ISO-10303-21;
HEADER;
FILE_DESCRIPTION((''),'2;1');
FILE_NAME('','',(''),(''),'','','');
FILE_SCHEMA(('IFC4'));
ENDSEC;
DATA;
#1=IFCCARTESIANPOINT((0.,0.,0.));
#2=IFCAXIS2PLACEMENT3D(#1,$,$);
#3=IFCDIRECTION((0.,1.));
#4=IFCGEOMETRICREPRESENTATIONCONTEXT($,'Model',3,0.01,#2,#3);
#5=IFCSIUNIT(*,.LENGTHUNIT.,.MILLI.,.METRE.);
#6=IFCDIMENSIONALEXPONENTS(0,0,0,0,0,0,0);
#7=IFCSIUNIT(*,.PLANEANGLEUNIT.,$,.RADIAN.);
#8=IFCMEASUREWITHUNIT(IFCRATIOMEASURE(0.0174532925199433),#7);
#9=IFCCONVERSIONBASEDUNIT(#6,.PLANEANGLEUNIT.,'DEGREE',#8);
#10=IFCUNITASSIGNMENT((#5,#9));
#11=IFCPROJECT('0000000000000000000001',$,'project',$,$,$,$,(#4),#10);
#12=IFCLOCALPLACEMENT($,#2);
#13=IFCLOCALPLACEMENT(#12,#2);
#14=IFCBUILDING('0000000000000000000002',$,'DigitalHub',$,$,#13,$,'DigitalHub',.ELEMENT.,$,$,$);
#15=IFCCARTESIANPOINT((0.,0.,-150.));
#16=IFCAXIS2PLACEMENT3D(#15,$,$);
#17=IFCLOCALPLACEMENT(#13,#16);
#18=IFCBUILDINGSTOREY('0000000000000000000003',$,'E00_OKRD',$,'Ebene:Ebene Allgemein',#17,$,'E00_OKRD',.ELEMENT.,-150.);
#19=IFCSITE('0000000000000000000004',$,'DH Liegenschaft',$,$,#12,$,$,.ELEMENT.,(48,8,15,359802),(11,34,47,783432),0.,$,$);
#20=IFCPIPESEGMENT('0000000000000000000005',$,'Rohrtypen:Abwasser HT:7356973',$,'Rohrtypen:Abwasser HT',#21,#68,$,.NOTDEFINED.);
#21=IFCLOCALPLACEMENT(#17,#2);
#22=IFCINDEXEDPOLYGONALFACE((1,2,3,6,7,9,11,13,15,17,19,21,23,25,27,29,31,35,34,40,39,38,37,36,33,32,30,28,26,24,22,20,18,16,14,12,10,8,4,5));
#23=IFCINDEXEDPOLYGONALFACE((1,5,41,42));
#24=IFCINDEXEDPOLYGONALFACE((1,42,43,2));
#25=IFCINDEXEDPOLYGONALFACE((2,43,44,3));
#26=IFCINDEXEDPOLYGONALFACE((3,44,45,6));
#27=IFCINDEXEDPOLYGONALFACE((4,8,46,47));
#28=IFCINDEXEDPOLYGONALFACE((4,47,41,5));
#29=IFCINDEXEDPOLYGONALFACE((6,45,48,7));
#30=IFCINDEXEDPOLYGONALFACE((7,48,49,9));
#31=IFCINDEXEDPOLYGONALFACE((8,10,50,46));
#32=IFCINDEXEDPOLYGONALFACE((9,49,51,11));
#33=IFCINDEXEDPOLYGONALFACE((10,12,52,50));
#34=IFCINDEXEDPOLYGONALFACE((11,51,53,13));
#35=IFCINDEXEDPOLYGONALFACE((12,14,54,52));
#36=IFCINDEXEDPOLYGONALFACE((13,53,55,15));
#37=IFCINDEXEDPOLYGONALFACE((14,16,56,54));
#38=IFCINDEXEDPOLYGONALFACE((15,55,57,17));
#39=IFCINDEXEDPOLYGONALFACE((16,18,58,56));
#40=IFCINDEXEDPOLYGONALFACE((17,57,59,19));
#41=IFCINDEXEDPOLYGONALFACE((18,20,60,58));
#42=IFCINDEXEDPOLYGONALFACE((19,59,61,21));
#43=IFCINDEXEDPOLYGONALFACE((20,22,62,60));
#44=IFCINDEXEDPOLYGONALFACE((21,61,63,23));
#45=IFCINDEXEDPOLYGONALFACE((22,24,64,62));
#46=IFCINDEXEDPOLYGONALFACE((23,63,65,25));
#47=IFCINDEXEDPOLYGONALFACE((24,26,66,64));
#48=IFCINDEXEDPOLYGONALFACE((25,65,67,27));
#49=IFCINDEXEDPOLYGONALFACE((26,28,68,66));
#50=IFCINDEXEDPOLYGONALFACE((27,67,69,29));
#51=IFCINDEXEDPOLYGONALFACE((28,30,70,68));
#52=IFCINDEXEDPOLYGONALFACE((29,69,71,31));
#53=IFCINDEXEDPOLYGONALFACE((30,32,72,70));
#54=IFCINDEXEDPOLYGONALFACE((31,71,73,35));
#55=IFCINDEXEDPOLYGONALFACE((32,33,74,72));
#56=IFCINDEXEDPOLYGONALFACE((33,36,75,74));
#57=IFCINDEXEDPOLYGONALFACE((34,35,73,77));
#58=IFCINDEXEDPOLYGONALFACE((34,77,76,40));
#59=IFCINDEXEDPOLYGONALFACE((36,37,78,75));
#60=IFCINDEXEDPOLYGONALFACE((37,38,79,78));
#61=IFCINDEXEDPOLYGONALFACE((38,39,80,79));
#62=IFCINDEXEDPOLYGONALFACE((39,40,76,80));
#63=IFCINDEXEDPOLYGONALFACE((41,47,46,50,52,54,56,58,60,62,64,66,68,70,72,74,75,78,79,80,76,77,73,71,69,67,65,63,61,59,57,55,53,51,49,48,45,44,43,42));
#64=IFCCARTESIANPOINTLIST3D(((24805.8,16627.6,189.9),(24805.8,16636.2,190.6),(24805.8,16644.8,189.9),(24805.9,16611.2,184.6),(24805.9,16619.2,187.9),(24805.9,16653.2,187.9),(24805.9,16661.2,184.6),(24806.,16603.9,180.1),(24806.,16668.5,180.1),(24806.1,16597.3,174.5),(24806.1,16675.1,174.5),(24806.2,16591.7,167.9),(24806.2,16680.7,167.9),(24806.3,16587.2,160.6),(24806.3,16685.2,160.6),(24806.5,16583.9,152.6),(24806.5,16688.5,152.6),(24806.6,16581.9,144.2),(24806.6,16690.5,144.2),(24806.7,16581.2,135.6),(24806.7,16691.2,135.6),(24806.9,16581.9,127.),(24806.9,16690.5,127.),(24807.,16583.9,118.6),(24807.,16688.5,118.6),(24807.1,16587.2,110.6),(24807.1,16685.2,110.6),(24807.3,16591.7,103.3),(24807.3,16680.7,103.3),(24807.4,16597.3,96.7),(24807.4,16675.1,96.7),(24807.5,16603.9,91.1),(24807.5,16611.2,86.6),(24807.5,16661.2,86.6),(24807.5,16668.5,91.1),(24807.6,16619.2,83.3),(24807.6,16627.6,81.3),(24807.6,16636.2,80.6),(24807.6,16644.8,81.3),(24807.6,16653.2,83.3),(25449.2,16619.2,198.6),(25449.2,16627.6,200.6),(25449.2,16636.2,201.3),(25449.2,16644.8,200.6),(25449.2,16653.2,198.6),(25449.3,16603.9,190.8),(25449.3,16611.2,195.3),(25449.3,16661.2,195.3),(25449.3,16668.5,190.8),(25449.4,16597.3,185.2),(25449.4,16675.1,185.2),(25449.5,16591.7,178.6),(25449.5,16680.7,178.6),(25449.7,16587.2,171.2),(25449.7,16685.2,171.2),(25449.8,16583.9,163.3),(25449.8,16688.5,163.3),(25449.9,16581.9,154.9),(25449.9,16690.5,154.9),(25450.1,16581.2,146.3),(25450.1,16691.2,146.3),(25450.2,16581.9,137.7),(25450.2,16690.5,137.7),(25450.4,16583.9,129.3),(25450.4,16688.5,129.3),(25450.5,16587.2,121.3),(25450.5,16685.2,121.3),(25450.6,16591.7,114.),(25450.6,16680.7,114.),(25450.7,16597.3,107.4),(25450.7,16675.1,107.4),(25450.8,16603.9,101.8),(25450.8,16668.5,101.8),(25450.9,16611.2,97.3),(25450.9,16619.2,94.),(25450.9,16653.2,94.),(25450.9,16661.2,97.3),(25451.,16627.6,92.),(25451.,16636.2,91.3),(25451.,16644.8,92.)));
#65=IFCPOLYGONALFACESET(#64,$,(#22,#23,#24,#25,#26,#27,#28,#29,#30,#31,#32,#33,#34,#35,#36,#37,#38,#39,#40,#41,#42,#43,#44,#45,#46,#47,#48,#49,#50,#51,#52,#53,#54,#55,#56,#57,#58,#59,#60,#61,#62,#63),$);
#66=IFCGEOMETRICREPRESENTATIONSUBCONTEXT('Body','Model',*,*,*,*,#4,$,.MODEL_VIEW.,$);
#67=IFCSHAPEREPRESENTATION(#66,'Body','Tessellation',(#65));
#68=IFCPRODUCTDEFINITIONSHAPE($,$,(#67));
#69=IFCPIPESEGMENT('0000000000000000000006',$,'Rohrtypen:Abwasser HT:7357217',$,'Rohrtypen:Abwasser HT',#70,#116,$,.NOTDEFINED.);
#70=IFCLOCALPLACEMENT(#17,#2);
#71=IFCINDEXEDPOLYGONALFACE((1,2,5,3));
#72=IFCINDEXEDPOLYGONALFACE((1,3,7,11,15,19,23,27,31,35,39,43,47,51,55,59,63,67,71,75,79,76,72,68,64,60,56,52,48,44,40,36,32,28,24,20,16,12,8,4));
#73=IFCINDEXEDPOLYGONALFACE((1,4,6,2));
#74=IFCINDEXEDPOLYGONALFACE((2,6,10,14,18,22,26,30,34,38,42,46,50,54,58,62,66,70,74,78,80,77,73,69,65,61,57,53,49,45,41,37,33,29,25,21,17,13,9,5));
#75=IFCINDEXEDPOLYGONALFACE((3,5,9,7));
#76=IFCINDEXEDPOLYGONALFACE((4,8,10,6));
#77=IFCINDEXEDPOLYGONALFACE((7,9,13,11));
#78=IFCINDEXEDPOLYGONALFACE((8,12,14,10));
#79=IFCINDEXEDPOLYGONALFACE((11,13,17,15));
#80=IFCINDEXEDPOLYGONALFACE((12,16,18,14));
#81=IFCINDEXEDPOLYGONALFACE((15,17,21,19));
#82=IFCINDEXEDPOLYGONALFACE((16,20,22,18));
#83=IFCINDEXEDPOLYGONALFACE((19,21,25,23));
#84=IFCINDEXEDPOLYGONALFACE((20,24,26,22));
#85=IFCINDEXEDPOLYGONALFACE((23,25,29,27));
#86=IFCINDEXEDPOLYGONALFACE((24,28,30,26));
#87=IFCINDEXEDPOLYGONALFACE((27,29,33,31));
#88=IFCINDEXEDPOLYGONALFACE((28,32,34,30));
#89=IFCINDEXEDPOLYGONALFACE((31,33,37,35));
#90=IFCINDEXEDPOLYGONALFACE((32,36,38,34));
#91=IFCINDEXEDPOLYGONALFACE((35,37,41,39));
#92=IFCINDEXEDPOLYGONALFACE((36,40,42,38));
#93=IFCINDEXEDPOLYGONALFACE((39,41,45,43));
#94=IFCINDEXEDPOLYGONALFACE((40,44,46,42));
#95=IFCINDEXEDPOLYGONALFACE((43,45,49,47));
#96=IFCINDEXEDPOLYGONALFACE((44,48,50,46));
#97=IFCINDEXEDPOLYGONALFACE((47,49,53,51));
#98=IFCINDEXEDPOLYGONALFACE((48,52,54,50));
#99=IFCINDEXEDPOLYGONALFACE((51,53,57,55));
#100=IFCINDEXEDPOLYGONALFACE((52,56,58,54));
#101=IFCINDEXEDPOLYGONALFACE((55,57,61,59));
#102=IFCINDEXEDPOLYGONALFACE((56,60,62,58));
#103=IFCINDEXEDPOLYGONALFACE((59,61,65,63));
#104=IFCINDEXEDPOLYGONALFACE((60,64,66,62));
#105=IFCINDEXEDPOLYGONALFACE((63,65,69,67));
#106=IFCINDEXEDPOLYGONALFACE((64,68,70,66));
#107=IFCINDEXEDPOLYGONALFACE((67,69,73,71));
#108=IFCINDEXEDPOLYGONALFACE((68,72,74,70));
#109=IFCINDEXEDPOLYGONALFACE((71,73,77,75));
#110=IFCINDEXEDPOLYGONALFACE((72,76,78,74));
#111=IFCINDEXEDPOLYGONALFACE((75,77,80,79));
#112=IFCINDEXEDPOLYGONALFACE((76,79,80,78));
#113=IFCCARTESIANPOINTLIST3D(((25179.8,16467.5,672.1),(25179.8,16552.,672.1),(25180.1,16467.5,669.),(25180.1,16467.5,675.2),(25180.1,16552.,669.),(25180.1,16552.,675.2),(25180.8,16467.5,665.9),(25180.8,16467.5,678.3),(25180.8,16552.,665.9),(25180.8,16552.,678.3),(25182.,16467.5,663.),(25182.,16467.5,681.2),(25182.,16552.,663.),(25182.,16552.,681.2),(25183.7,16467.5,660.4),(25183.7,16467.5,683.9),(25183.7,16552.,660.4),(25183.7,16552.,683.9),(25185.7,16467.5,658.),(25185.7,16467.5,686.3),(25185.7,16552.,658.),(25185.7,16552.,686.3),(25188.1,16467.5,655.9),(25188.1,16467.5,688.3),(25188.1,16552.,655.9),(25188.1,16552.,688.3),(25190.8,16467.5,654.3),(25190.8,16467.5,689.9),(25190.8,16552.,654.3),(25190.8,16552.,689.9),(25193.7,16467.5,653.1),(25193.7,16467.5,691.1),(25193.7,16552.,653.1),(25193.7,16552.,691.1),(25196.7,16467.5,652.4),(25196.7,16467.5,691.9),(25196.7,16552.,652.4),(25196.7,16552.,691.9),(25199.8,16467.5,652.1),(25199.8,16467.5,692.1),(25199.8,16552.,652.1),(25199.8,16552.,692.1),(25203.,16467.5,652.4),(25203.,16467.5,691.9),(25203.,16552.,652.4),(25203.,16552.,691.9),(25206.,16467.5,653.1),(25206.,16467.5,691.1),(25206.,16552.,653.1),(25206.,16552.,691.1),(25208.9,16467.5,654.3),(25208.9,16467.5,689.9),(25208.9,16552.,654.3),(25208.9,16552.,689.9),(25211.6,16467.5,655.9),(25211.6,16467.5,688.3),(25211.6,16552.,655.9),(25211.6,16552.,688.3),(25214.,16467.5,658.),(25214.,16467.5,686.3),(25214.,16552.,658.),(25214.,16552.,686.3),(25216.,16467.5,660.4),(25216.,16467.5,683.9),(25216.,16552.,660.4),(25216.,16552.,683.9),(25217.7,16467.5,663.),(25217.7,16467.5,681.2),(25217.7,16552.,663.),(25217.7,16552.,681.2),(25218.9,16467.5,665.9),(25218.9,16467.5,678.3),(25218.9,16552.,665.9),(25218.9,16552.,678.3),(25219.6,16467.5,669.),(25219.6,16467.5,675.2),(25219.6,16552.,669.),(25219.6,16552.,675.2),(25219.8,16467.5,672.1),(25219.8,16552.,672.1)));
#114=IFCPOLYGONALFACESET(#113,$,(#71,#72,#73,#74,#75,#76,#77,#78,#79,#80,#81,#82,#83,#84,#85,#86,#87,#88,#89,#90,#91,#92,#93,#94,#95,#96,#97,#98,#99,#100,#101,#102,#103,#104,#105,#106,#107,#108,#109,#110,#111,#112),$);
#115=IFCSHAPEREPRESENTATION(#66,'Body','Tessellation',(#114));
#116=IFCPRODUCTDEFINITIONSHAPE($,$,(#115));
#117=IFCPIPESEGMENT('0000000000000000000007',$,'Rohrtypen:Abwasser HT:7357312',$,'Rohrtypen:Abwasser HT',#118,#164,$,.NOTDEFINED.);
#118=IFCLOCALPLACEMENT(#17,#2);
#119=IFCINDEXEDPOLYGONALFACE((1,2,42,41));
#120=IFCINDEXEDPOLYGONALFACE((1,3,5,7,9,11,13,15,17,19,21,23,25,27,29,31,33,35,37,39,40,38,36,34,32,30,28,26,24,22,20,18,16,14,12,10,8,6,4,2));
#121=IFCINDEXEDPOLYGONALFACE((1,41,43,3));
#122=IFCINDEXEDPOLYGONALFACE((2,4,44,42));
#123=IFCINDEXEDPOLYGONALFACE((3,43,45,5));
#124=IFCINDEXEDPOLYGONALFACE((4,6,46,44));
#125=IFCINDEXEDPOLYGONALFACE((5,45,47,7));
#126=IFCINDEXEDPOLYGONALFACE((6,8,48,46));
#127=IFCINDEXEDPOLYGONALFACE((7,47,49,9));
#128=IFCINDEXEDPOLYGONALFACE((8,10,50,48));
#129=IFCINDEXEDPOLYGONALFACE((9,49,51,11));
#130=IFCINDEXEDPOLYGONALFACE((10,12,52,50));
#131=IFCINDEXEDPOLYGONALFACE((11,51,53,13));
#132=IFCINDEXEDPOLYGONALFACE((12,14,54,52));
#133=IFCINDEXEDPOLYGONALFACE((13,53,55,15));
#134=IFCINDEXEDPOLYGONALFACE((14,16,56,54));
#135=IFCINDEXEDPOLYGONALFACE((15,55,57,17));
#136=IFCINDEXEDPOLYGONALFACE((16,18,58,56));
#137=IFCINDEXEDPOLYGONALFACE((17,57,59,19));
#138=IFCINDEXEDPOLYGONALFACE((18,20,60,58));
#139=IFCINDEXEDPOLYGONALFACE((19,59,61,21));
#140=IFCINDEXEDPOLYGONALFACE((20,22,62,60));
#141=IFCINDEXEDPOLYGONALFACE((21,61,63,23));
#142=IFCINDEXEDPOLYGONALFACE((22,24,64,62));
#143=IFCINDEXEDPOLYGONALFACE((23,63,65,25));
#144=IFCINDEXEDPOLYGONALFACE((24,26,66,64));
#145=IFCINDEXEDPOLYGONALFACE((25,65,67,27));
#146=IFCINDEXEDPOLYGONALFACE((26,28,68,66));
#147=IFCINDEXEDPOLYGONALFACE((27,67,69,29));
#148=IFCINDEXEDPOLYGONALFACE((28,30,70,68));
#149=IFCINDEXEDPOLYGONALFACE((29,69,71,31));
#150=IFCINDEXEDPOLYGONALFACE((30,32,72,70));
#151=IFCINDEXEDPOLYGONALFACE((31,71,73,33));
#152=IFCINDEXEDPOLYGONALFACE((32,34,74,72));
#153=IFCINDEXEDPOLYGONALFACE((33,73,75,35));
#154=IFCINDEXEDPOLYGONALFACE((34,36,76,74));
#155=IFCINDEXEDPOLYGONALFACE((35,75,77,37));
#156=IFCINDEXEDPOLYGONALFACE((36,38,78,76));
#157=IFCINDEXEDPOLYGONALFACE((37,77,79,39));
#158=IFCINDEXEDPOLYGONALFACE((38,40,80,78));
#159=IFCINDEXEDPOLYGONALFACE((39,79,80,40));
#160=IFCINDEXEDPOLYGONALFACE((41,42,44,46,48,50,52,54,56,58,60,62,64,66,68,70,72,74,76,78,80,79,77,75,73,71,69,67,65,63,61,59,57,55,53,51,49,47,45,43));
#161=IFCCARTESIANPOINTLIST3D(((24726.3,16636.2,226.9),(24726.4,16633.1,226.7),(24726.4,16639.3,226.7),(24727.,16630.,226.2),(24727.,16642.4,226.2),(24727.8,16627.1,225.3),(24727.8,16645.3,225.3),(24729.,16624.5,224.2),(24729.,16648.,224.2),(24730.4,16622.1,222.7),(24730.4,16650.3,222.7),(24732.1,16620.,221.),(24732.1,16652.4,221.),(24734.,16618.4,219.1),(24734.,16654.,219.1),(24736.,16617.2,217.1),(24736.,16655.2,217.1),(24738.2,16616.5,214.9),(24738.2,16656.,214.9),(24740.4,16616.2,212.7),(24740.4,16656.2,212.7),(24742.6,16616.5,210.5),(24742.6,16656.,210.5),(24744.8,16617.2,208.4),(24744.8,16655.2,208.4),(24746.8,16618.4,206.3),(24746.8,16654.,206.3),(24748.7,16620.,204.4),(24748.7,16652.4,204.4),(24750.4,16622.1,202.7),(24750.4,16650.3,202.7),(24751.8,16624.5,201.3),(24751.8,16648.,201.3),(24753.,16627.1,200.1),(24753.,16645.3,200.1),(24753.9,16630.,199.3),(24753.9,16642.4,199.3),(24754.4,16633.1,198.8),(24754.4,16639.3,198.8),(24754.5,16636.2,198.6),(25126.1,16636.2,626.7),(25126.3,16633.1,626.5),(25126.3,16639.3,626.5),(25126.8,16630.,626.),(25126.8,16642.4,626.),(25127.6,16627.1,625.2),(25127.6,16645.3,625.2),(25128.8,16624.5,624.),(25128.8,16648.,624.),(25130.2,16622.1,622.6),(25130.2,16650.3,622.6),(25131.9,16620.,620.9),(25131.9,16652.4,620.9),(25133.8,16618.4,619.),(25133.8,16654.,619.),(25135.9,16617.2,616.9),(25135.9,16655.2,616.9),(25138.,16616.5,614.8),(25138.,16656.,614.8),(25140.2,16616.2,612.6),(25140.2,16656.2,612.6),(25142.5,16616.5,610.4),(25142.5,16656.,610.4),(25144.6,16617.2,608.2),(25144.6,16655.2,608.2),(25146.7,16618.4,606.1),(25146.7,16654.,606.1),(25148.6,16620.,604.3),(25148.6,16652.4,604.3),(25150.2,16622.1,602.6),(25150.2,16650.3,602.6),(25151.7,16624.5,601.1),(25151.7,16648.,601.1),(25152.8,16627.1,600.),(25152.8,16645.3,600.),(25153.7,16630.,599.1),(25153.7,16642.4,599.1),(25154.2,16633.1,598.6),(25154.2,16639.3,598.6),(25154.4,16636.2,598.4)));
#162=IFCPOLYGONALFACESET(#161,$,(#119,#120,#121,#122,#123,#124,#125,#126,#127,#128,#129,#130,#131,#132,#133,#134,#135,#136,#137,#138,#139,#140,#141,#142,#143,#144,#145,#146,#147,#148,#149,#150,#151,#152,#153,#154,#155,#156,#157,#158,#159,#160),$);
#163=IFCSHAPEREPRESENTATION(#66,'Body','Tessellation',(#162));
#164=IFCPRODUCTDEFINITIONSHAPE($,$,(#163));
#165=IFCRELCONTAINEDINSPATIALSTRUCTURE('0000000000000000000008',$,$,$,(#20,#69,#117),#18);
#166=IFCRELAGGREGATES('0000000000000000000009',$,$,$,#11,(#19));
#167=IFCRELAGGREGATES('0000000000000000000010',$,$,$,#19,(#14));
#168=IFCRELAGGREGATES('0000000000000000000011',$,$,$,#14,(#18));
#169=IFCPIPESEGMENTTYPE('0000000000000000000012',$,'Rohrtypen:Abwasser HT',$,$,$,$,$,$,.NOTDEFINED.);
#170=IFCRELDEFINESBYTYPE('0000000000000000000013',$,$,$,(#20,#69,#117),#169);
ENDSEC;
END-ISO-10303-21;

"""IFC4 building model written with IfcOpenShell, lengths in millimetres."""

from ifc_helpers import new_model, entity, si_unit, converted_unit, direction, frame, origin, place, context, subcontext, project, spatial, indexed_curve, outline, extrude, type_object, element, save


model = new_model("IFC4")

# Units and contexts
model_context = context("Model", 3, precision=0.01, world=origin(), true_north=direction((0.0, 1.0)))
body_context = subcontext(model_context, "Body", "Model", "MODEL_VIEW")
ifc_project = project(units=[si_unit("LENGTHUNIT", "METRE", prefix="MILLI"), converted_unit("PLANEANGLEUNIT", "DEGREE", entity("IfcRatioMeasure", 0.0174532925199433), si_unit("PLANEANGLEUNIT", "RADIAN"), dimensions=[0, 0, 0, 0, 0, 0, 0])], contexts=[model_context])

# Site, building, storey
site_placement = place(None, origin())
site = spatial("IfcSite", under=ifc_project, at=site_placement, Name="DH Liegenschaft", CompositionType="ELEMENT", RefLatitude=(48, 8, 15, 359802), RefLongitude=(11, 34, 47, 783432), RefElevation=0.0)
building_placement = place(site_placement, origin())
building = spatial("IfcBuilding", under=site, at=building_placement, Name="DigitalHub", LongName="DigitalHub", CompositionType="ELEMENT")
storey_placement = place(building_placement, frame((0.0, 0.0, -150.0)))
storey = spatial("IfcBuildingStorey", under=building, at=storey_placement, Name="E00_OKRD", ObjectType="Ebene:Ebene Allgemein", LongName="E00_OKRD", CompositionType="ELEMENT", Elevation=-150.0)

# Pipe segments
pipe_segment_type_1 = type_object("IfcPipeSegmentType", Name="Rohrtypen:Abwasser HT", PredefinedType="NOTDEFINED")
pipe_segment_1_placement = place(storey_placement, frame((24804.2, 16579.6, 79.0)))
element("IfcPipeSegment", 1, at=pipe_segment_1_placement, inside=storey, type_object=pipe_segment_type_1, Name="Rohrtypen:Abwasser HT:7356973", ObjectType="Rohrtypen:Abwasser HT", PredefinedType="NOTDEFINED", context=body_context, shape_type="SweptSolid", body=[
    extrude(outline(indexed_curve([(55.0, 0.0), (54.3, 8.6), (52.3, 17.0), (49.0, 25.0), (44.5, 32.3), (38.9, 38.9), (32.3, 44.5), (25.0, 49.0), (17.0, 52.3), (8.6, 54.3), (0.0, 55.0), (-8.6, 54.3), (-17.0, 52.3), (-25.0, 49.0), (-32.3, 44.5), (-38.9, 38.9), (-44.5, 32.3), (-49.0, 25.0), (-52.3, 17.0), (-54.3, 8.6), (-55.0, 0.0), (-54.3, -8.6), (-52.3, -17.0), (-49.0, -25.0), (-44.5, -32.3), (-38.9, -38.9), (-32.3, -44.5), (-25.0, -49.0), (-17.0, -52.3), (-8.6, -54.3), (0.0, -55.0), (8.6, -54.3), (17.0, -52.3), (25.0, -49.0), (32.3, -44.5), (38.9, -38.9), (44.5, -32.3), (49.0, -25.0), (52.3, -17.0), (54.3, -8.6), (55.0, 0.0)], self_intersect=False)), frame((2.5, 56.6, 56.6), z_axis=(0.999862, 0.0, 0.016604), x_axis=(0.0, -1.0, 0.0)), (0.0, 0.0, 1.0), 643.4),
])
pipe_segment_2_placement = place(storey_placement, frame((25178.2, 16467.5, 650.5)))
element("IfcPipeSegment", 2, at=pipe_segment_2_placement, inside=storey, type_object=pipe_segment_type_1, Name="Rohrtypen:Abwasser HT:7357217", ObjectType="Rohrtypen:Abwasser HT", PredefinedType="NOTDEFINED", context=body_context, shape_type="SweptSolid", body=[
    extrude(outline(indexed_curve([(20.0, 0.0), (19.8, 3.1), (19.0, 6.2), (17.8, 9.1), (16.2, 11.8), (14.1, 14.1), (11.8, 16.2), (9.1, 17.8), (6.2, 19.0), (3.1, 19.8), (0.0, 20.0), (-3.1, 19.8), (-6.2, 19.0), (-9.1, 17.8), (-11.8, 16.2), (-14.1, 14.1), (-16.2, 11.8), (-17.8, 9.1), (-19.0, 6.2), (-19.8, 3.1), (-20.0, 0.0), (-19.8, -3.1), (-19.0, -6.2), (-17.8, -9.1), (-16.2, -11.8), (-14.1, -14.1), (-11.8, -16.2), (-9.1, -17.8), (-6.2, -19.0), (-3.1, -19.8), (0.0, -20.0), (3.1, -19.8), (6.2, -19.0), (9.1, -17.8), (11.8, -16.2), (14.1, -14.1), (16.2, -11.8), (17.8, -9.1), (19.0, -6.2), (19.8, -3.1), (20.0, 0.0)], self_intersect=False)), frame((21.6, 0.0, 21.6), z_axis=(0.000043, 1.0, 0.0), x_axis=(1.0, -0.000043, 0.0)), (0.0, 0.0, 1.0), 84.4),
])
pipe_segment_3_placement = place(storey_placement, frame((24724.7, 16614.6, 197.0)))
element("IfcPipeSegment", 3, at=pipe_segment_3_placement, inside=storey, type_object=pipe_segment_type_1, Name="Rohrtypen:Abwasser HT:7357312", ObjectType="Rohrtypen:Abwasser HT", PredefinedType="NOTDEFINED", context=body_context, shape_type="SweptSolid", body=[
    extrude(outline(indexed_curve([(20.0, 0.0), (19.8, 3.1), (19.0, 6.2), (17.8, 9.1), (16.2, 11.8), (14.1, 14.1), (11.8, 16.2), (9.1, 17.8), (6.2, 19.0), (3.1, 19.8), (0.0, 20.0), (-3.1, 19.8), (-6.2, 19.0), (-9.1, 17.8), (-11.8, 16.2), (-14.1, 14.1), (-16.2, 11.8), (-17.8, 9.1), (-19.0, 6.2), (-19.8, 3.1), (-20.0, 0.0), (-19.8, -3.1), (-19.0, -6.2), (-17.8, -9.1), (-16.2, -11.8), (-14.1, -14.1), (-11.8, -16.2), (-9.1, -17.8), (-6.2, -19.0), (-3.1, -19.8), (0.0, -20.0), (3.1, -19.8), (6.2, -19.0), (9.1, -17.8), (11.8, -16.2), (14.1, -14.1), (16.2, -11.8), (17.8, -9.1), (19.0, -6.2), (19.8, -3.1), (20.0, 0.0)], self_intersect=False)), frame((15.7, 21.6, 15.7), z_axis=(0.707107, 0.0, 0.707107), x_axis=(0.0, -1.0, 0.0)), (0.0, 0.0, 1.0), 565.5),
])

save(model, "model.ifc")
